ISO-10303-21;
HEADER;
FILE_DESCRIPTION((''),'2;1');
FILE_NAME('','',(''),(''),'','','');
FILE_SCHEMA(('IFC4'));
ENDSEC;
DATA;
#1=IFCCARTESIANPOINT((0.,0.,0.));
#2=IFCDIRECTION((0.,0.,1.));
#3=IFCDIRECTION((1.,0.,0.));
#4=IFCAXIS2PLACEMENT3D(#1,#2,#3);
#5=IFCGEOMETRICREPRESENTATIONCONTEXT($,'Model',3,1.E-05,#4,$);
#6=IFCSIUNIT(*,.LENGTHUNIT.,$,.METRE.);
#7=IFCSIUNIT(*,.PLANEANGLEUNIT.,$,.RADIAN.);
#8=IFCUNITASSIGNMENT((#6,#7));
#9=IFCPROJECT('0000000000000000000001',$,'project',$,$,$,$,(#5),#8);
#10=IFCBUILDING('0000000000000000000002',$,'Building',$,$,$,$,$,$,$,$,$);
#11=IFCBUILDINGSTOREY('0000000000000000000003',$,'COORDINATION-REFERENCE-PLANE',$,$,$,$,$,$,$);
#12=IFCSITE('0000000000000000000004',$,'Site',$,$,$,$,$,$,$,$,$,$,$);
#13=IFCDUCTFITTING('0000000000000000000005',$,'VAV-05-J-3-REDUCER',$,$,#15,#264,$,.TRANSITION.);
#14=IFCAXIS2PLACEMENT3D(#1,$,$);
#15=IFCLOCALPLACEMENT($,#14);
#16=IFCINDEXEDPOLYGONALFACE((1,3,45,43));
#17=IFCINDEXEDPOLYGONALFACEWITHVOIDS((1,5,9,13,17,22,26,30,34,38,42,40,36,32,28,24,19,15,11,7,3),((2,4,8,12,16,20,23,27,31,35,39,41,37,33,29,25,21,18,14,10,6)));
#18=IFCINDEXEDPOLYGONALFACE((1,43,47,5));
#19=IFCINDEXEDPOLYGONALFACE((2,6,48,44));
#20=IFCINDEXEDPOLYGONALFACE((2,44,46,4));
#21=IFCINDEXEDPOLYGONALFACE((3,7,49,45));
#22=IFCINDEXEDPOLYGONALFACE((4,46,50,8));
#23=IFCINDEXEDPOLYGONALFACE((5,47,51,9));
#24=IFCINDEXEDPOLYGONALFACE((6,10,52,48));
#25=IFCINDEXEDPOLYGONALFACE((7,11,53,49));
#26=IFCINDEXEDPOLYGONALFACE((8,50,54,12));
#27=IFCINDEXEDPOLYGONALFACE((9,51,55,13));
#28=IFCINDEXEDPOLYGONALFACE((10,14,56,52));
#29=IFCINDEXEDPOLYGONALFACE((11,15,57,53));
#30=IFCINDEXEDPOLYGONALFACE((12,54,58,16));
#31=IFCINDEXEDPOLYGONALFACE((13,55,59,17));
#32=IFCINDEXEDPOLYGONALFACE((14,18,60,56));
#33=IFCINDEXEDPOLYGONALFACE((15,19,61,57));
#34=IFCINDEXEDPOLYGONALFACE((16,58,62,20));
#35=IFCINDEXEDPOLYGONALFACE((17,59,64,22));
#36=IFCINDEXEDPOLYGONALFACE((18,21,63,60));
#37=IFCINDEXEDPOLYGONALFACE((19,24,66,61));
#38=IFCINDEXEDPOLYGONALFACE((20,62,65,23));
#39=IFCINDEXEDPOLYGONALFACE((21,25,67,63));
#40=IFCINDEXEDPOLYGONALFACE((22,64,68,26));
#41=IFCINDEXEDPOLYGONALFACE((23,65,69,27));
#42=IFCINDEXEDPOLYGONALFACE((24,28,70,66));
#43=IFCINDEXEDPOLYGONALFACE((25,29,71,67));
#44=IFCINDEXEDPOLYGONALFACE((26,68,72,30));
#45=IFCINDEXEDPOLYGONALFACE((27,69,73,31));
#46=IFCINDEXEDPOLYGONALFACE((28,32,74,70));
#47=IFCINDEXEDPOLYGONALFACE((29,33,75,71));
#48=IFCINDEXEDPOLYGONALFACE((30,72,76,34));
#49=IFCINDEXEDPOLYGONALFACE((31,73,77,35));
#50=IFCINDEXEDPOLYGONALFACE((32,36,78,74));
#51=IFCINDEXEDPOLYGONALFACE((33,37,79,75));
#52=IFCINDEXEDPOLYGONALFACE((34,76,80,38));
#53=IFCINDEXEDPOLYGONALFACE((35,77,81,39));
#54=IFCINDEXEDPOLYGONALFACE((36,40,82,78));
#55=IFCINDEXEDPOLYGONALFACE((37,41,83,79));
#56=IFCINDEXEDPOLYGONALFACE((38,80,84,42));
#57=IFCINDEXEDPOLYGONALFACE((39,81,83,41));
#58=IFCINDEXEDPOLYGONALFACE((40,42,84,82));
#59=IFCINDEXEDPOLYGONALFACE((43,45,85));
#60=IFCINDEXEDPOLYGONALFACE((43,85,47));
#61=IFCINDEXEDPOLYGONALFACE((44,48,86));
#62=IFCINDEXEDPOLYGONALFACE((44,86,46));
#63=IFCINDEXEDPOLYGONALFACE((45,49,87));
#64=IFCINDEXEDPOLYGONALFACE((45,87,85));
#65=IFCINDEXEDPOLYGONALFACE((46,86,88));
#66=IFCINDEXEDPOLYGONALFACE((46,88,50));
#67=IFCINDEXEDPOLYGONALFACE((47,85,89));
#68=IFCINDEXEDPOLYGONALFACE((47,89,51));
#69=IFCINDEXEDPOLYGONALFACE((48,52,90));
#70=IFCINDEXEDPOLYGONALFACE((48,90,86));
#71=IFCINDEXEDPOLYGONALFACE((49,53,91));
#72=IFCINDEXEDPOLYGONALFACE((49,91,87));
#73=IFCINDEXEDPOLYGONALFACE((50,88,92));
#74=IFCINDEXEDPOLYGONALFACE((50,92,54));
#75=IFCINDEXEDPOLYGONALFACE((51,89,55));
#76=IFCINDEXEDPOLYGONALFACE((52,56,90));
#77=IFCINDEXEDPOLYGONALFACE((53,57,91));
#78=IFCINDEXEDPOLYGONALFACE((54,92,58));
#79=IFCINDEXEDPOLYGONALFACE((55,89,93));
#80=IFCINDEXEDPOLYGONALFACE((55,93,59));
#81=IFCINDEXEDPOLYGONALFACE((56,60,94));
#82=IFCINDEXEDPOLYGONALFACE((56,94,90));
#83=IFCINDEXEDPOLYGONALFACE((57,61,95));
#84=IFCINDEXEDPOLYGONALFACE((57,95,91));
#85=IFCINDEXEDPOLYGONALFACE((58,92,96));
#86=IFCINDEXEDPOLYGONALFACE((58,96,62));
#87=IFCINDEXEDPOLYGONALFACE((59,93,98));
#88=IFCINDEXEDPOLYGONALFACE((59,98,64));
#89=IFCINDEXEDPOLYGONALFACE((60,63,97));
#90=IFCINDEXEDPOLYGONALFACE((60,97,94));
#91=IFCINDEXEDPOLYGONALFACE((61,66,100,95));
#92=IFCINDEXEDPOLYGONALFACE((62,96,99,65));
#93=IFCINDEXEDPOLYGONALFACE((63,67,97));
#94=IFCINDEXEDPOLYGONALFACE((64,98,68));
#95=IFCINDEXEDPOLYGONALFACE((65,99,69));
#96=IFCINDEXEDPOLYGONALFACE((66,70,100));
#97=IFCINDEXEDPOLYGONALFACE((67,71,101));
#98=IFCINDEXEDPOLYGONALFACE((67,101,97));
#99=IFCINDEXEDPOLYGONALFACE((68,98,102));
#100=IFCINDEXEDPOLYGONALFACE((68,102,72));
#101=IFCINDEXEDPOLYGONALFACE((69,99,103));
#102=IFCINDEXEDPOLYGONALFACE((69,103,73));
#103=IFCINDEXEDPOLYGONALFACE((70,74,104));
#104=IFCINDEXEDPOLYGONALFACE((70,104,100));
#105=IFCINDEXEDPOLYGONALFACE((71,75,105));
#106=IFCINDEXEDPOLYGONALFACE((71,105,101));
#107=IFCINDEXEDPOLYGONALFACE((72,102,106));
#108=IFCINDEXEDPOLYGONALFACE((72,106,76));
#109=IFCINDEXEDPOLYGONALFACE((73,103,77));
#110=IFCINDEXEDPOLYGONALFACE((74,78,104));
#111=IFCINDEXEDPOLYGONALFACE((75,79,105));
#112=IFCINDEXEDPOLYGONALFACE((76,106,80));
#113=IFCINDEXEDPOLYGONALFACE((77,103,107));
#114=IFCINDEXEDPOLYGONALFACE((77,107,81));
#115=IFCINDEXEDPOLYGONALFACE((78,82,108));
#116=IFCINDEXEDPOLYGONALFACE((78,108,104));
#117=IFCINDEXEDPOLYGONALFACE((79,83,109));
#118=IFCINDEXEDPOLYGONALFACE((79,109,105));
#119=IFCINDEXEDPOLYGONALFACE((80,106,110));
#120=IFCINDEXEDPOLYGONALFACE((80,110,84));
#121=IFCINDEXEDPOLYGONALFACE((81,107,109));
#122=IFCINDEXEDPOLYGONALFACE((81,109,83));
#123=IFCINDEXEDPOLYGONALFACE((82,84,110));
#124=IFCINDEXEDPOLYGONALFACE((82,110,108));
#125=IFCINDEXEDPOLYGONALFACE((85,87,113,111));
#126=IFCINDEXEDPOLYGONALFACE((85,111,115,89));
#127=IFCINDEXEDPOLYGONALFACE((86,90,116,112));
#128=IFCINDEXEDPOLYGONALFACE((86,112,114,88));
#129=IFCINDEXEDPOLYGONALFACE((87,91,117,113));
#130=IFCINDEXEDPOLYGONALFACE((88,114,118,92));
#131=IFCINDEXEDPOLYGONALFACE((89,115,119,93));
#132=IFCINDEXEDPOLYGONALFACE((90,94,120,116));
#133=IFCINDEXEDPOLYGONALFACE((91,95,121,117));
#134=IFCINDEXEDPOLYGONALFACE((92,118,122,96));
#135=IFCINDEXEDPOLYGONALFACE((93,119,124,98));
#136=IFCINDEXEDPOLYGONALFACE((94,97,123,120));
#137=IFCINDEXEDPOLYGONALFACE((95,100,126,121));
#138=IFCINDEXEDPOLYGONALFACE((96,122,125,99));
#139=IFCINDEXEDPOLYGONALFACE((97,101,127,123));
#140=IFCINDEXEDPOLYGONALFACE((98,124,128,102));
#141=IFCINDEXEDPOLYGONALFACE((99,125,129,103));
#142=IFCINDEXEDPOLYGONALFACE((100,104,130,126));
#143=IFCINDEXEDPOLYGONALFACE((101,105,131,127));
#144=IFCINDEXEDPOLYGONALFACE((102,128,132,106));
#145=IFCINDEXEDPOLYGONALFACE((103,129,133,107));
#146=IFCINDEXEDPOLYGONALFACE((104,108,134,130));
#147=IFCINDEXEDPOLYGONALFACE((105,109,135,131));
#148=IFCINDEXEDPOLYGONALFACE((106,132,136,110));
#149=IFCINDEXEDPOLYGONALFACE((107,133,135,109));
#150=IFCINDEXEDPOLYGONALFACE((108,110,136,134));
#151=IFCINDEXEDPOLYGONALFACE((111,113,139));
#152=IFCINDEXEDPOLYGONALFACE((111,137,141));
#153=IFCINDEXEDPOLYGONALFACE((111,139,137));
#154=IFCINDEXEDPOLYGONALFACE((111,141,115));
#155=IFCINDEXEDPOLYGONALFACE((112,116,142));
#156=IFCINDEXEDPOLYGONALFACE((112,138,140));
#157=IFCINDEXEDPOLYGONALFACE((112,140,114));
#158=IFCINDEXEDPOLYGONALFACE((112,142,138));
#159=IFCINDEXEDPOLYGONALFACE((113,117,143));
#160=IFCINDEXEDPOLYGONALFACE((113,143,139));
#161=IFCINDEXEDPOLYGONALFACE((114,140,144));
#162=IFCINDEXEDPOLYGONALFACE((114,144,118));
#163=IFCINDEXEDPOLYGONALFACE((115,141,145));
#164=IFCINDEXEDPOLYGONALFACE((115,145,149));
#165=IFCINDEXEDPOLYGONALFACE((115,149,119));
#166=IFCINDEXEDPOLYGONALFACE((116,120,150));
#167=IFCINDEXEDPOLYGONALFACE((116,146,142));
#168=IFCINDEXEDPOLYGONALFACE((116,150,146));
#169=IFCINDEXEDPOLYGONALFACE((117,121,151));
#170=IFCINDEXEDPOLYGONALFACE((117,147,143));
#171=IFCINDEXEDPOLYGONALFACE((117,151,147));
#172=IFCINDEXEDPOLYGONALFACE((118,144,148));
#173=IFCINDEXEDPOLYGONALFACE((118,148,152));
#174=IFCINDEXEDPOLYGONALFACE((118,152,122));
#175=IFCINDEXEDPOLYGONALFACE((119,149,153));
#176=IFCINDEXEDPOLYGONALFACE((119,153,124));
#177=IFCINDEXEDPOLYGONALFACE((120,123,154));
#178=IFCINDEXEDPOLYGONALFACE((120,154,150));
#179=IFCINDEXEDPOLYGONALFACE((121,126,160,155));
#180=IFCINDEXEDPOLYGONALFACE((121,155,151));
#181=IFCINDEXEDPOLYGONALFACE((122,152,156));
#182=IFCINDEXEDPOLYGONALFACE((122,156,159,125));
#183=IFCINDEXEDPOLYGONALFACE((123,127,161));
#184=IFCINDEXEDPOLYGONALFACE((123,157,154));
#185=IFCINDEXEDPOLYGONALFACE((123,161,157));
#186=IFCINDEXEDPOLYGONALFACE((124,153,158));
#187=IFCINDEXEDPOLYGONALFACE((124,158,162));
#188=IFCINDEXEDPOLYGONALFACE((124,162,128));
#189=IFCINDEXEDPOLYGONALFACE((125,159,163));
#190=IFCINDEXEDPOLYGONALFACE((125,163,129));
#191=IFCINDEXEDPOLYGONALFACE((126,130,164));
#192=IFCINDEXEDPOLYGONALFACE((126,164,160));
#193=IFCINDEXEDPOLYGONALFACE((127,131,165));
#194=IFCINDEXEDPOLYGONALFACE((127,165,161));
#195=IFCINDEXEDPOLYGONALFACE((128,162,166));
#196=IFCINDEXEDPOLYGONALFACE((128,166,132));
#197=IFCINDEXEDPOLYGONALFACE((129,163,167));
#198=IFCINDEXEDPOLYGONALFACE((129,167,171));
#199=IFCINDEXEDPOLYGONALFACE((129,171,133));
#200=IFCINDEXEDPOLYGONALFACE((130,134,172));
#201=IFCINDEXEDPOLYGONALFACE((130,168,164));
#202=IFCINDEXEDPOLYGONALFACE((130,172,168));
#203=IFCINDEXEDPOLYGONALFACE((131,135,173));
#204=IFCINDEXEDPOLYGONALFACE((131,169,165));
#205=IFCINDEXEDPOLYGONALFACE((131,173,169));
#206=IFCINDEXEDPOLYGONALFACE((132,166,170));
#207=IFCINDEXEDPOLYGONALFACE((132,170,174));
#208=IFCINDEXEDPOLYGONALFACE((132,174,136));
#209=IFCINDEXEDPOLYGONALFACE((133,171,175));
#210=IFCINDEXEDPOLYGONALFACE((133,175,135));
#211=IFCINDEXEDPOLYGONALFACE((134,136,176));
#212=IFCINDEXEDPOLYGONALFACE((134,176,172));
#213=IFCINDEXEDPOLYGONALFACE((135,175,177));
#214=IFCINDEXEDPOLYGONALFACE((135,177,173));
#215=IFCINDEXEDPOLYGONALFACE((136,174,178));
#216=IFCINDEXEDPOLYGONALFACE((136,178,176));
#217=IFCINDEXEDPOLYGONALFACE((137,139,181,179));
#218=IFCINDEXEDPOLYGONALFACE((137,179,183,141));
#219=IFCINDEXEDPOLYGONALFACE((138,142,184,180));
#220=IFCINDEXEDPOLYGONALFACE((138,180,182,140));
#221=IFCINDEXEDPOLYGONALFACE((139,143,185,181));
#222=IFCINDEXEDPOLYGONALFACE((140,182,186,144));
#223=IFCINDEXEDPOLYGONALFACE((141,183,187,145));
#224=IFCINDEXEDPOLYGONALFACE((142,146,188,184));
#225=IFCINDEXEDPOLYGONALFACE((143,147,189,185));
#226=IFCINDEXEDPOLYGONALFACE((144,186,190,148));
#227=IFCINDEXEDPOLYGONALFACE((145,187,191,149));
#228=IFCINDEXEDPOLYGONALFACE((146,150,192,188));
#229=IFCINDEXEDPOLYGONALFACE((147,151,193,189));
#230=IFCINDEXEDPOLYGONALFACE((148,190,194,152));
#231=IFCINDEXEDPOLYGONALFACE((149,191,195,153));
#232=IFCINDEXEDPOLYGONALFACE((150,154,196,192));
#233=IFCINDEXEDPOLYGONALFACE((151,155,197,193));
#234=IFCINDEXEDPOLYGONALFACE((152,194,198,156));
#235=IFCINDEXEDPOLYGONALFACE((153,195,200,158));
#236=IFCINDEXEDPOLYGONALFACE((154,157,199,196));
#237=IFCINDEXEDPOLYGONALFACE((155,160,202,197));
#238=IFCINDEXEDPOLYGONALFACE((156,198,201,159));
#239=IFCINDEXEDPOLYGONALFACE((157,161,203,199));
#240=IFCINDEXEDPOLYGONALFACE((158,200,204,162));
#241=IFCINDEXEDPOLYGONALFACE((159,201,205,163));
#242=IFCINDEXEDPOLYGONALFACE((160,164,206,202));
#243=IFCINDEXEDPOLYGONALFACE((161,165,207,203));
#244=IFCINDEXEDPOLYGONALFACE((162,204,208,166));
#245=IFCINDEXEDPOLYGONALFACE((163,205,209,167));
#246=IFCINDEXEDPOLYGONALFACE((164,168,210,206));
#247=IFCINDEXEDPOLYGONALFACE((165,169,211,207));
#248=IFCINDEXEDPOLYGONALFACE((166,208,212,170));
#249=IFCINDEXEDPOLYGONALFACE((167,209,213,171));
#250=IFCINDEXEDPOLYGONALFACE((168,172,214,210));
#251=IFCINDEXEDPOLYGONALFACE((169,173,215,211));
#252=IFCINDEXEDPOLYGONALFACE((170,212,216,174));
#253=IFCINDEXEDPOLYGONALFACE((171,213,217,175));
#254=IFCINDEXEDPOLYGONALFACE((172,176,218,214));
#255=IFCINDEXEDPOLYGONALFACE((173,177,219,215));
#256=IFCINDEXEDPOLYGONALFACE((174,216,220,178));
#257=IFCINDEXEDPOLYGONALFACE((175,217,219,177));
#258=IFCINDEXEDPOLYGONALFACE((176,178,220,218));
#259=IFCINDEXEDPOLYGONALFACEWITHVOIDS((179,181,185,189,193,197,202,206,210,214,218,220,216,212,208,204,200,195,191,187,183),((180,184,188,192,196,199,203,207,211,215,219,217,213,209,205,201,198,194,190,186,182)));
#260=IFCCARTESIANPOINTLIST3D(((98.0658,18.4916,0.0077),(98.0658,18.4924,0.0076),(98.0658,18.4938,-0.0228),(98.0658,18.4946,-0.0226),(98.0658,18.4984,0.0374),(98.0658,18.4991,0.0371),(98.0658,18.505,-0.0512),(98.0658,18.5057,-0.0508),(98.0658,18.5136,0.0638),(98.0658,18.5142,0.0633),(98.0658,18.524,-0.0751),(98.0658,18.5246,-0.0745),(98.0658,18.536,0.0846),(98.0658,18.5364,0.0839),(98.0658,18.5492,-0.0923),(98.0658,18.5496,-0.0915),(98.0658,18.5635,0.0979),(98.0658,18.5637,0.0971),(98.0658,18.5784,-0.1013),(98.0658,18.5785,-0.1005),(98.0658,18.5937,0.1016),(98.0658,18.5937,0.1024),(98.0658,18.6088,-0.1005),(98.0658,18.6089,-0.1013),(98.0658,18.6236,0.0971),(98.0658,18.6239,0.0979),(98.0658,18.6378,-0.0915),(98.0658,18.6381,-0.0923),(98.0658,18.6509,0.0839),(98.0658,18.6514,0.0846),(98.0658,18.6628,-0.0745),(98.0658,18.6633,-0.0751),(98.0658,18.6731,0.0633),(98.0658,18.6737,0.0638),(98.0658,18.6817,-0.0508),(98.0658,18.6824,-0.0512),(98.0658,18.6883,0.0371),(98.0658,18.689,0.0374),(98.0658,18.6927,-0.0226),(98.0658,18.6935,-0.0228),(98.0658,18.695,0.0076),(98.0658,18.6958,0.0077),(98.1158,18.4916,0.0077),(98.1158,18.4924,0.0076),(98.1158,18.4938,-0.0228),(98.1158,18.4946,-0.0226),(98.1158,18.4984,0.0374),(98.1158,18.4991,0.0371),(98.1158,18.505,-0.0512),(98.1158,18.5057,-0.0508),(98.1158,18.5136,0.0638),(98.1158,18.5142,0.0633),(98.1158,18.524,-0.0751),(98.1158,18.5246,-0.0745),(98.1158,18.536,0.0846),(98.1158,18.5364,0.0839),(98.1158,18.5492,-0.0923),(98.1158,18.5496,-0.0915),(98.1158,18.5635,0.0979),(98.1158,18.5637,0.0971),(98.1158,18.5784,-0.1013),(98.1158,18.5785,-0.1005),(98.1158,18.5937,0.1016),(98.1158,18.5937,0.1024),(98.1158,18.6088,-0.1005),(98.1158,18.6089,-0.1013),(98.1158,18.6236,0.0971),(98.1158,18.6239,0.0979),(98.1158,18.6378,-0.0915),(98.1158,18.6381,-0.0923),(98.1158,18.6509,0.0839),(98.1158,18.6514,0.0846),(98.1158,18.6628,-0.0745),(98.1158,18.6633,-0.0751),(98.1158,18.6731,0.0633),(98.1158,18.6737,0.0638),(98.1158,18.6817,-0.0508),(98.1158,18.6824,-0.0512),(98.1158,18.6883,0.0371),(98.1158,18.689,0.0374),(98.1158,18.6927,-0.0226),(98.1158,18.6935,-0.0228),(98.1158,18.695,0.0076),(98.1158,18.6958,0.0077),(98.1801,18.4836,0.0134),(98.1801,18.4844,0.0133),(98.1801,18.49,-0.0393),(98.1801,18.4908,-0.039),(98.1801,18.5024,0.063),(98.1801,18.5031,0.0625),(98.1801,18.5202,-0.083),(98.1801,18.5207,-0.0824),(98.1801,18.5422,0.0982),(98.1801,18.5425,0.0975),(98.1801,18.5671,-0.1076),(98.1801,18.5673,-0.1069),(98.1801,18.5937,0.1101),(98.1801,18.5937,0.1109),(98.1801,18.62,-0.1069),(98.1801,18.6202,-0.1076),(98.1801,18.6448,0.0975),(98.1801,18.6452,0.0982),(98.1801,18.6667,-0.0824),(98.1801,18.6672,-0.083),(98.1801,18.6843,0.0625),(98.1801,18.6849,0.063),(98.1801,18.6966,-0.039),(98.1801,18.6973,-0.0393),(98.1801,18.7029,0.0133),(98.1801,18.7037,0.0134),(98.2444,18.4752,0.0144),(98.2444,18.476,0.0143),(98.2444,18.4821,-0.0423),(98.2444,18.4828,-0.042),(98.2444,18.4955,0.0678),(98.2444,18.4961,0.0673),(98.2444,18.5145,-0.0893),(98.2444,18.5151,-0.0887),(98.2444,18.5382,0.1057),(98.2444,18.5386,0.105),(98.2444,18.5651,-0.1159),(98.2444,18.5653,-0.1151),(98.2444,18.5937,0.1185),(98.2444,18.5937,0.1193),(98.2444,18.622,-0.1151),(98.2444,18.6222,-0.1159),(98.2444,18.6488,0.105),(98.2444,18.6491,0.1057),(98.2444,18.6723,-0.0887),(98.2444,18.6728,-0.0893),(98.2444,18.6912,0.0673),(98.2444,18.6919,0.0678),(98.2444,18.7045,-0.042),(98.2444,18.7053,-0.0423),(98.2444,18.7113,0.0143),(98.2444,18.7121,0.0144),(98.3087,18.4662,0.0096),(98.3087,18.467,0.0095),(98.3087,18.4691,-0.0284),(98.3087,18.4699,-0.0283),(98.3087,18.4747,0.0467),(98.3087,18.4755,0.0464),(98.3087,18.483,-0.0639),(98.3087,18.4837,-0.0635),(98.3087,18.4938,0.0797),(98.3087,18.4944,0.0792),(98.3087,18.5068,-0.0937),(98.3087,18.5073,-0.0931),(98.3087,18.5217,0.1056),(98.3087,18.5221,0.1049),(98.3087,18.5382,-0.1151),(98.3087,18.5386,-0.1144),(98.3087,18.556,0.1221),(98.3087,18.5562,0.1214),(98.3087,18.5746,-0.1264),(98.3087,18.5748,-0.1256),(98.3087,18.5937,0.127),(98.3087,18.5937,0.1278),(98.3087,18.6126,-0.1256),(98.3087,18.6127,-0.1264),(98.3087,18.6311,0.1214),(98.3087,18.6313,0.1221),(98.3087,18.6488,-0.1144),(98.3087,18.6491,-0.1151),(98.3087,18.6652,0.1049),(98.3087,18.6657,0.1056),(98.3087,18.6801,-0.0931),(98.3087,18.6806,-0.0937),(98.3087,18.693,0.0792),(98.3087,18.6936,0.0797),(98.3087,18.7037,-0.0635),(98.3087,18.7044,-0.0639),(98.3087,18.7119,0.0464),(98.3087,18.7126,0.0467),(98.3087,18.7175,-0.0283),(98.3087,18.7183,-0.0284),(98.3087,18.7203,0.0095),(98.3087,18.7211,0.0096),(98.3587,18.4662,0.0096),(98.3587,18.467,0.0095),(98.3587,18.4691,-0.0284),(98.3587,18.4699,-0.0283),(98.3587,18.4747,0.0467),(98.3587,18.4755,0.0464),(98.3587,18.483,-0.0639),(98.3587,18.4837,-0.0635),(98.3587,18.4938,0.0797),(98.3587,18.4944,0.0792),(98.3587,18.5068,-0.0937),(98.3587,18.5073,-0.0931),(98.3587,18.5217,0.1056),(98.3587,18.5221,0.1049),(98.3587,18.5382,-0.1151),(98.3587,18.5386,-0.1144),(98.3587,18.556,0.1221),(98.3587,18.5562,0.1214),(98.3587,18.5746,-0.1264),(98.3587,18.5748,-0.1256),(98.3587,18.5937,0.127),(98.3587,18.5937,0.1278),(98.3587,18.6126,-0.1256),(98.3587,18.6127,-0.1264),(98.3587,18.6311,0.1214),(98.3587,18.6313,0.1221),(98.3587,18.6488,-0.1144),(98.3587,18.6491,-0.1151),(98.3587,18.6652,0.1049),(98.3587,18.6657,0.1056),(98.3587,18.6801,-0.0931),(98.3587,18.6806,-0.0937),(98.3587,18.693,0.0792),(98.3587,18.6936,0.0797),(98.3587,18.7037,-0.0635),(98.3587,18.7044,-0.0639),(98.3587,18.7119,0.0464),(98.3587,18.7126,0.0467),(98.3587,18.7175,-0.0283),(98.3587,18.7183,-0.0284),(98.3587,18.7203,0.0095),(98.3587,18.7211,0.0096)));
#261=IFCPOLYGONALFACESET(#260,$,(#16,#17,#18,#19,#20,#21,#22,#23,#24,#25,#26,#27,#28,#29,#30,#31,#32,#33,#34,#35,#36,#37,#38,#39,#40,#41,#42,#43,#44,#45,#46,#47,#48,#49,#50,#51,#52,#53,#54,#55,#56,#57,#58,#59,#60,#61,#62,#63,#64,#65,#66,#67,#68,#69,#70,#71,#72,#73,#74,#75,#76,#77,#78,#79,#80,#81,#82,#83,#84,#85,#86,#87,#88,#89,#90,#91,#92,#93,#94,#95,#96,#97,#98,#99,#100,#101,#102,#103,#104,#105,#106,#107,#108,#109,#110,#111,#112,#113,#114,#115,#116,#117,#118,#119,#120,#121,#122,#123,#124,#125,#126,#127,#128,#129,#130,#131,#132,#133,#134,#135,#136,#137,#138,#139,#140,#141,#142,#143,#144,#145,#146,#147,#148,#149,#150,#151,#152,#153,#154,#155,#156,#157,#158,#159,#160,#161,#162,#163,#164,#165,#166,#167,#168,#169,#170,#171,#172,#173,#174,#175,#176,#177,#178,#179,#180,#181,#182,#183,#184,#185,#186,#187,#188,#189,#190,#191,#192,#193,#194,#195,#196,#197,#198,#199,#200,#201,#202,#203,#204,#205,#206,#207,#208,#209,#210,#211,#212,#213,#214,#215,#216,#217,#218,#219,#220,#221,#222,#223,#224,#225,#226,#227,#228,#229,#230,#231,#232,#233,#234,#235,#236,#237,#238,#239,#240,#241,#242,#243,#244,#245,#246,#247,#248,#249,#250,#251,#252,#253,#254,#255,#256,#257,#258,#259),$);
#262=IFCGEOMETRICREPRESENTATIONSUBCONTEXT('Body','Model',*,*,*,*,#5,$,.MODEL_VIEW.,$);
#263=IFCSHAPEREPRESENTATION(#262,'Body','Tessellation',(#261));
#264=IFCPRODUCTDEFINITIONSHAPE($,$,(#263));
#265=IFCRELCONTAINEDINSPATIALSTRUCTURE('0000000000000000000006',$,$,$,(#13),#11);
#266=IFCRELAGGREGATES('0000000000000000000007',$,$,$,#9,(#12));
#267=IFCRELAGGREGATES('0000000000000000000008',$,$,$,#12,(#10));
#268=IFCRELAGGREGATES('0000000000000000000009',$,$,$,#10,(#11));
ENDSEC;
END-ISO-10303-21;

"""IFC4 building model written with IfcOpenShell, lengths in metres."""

from ifc_helpers import new_model, entity, si_unit, frame, origin_with_axes, place, context, subcontext, project, spatial, element, save


model = new_model("IFC4")

# Units and contexts
model_context_1 = context("Model", 3, precision=1e-05, world=origin_with_axes())
body_context_1 = subcontext(model_context_1, "Body", "Model", "MODEL_VIEW")
ifc_project = project(units=[si_unit("LENGTHUNIT", "METRE"), si_unit("PLANEANGLEUNIT", "RADIAN")], contexts=[model_context_1])

# Site, building, storey
site = spatial("IfcSite", under=ifc_project, Name="Site")
building = spatial("IfcBuilding", under=site, Name="Building")
storey = spatial("IfcBuildingStorey", under=building, Name="COORDINATION-REFERENCE-PLANE")

# Duct fitting
for number, where, z_axis, x_axis, name in (
    (1, (98.3587, 18.5937, 0.0), (0.0, -1.0, 0.0), (0.0, 0.0, 1.0), "VAV-05-J-3-REDUCER"),
):
    element("IfcDuctFitting", number, at=place(None, frame(where, z_axis=z_axis, x_axis=x_axis)), inside=storey, Name=name, PredefinedType="TRANSITION", context=body_context_1, shape_type="SweptSolid", body=[
        entity("IfcRevolvedAreaSolid", entity("IfcArbitraryClosedProfileDef", "AREA", None, entity("IfcPolyline", [entity("IfcCartesianPoint", [0.1278, 0.0]), entity("IfcCartesianPoint", [0.1278, 0.05]), entity("IfcCartesianPoint", [0.1024, 0.2429]), entity("IfcCartesianPoint", [0.1024, 0.2929]), entity("IfcCartesianPoint", [0.1016, 0.2929]), entity("IfcCartesianPoint", [0.1016, 0.2429]), entity("IfcCartesianPoint", [0.127, 0.05]), entity("IfcCartesianPoint", [0.127, 0.0]), entity("IfcCartesianPoint", [0.1278, 0.0])])), entity("IfcAxis2Placement3D", entity("IfcCartesianPoint", [0.0, 0.0, 0.0])), entity("IfcAxis1Placement", entity("IfcCartesianPoint", [0.0, 0.0, 0.0]), entity("IfcDirection", [0.0, 1.0, 0.0])), 6.283185),
    ])

save(model, "model.ifc")
